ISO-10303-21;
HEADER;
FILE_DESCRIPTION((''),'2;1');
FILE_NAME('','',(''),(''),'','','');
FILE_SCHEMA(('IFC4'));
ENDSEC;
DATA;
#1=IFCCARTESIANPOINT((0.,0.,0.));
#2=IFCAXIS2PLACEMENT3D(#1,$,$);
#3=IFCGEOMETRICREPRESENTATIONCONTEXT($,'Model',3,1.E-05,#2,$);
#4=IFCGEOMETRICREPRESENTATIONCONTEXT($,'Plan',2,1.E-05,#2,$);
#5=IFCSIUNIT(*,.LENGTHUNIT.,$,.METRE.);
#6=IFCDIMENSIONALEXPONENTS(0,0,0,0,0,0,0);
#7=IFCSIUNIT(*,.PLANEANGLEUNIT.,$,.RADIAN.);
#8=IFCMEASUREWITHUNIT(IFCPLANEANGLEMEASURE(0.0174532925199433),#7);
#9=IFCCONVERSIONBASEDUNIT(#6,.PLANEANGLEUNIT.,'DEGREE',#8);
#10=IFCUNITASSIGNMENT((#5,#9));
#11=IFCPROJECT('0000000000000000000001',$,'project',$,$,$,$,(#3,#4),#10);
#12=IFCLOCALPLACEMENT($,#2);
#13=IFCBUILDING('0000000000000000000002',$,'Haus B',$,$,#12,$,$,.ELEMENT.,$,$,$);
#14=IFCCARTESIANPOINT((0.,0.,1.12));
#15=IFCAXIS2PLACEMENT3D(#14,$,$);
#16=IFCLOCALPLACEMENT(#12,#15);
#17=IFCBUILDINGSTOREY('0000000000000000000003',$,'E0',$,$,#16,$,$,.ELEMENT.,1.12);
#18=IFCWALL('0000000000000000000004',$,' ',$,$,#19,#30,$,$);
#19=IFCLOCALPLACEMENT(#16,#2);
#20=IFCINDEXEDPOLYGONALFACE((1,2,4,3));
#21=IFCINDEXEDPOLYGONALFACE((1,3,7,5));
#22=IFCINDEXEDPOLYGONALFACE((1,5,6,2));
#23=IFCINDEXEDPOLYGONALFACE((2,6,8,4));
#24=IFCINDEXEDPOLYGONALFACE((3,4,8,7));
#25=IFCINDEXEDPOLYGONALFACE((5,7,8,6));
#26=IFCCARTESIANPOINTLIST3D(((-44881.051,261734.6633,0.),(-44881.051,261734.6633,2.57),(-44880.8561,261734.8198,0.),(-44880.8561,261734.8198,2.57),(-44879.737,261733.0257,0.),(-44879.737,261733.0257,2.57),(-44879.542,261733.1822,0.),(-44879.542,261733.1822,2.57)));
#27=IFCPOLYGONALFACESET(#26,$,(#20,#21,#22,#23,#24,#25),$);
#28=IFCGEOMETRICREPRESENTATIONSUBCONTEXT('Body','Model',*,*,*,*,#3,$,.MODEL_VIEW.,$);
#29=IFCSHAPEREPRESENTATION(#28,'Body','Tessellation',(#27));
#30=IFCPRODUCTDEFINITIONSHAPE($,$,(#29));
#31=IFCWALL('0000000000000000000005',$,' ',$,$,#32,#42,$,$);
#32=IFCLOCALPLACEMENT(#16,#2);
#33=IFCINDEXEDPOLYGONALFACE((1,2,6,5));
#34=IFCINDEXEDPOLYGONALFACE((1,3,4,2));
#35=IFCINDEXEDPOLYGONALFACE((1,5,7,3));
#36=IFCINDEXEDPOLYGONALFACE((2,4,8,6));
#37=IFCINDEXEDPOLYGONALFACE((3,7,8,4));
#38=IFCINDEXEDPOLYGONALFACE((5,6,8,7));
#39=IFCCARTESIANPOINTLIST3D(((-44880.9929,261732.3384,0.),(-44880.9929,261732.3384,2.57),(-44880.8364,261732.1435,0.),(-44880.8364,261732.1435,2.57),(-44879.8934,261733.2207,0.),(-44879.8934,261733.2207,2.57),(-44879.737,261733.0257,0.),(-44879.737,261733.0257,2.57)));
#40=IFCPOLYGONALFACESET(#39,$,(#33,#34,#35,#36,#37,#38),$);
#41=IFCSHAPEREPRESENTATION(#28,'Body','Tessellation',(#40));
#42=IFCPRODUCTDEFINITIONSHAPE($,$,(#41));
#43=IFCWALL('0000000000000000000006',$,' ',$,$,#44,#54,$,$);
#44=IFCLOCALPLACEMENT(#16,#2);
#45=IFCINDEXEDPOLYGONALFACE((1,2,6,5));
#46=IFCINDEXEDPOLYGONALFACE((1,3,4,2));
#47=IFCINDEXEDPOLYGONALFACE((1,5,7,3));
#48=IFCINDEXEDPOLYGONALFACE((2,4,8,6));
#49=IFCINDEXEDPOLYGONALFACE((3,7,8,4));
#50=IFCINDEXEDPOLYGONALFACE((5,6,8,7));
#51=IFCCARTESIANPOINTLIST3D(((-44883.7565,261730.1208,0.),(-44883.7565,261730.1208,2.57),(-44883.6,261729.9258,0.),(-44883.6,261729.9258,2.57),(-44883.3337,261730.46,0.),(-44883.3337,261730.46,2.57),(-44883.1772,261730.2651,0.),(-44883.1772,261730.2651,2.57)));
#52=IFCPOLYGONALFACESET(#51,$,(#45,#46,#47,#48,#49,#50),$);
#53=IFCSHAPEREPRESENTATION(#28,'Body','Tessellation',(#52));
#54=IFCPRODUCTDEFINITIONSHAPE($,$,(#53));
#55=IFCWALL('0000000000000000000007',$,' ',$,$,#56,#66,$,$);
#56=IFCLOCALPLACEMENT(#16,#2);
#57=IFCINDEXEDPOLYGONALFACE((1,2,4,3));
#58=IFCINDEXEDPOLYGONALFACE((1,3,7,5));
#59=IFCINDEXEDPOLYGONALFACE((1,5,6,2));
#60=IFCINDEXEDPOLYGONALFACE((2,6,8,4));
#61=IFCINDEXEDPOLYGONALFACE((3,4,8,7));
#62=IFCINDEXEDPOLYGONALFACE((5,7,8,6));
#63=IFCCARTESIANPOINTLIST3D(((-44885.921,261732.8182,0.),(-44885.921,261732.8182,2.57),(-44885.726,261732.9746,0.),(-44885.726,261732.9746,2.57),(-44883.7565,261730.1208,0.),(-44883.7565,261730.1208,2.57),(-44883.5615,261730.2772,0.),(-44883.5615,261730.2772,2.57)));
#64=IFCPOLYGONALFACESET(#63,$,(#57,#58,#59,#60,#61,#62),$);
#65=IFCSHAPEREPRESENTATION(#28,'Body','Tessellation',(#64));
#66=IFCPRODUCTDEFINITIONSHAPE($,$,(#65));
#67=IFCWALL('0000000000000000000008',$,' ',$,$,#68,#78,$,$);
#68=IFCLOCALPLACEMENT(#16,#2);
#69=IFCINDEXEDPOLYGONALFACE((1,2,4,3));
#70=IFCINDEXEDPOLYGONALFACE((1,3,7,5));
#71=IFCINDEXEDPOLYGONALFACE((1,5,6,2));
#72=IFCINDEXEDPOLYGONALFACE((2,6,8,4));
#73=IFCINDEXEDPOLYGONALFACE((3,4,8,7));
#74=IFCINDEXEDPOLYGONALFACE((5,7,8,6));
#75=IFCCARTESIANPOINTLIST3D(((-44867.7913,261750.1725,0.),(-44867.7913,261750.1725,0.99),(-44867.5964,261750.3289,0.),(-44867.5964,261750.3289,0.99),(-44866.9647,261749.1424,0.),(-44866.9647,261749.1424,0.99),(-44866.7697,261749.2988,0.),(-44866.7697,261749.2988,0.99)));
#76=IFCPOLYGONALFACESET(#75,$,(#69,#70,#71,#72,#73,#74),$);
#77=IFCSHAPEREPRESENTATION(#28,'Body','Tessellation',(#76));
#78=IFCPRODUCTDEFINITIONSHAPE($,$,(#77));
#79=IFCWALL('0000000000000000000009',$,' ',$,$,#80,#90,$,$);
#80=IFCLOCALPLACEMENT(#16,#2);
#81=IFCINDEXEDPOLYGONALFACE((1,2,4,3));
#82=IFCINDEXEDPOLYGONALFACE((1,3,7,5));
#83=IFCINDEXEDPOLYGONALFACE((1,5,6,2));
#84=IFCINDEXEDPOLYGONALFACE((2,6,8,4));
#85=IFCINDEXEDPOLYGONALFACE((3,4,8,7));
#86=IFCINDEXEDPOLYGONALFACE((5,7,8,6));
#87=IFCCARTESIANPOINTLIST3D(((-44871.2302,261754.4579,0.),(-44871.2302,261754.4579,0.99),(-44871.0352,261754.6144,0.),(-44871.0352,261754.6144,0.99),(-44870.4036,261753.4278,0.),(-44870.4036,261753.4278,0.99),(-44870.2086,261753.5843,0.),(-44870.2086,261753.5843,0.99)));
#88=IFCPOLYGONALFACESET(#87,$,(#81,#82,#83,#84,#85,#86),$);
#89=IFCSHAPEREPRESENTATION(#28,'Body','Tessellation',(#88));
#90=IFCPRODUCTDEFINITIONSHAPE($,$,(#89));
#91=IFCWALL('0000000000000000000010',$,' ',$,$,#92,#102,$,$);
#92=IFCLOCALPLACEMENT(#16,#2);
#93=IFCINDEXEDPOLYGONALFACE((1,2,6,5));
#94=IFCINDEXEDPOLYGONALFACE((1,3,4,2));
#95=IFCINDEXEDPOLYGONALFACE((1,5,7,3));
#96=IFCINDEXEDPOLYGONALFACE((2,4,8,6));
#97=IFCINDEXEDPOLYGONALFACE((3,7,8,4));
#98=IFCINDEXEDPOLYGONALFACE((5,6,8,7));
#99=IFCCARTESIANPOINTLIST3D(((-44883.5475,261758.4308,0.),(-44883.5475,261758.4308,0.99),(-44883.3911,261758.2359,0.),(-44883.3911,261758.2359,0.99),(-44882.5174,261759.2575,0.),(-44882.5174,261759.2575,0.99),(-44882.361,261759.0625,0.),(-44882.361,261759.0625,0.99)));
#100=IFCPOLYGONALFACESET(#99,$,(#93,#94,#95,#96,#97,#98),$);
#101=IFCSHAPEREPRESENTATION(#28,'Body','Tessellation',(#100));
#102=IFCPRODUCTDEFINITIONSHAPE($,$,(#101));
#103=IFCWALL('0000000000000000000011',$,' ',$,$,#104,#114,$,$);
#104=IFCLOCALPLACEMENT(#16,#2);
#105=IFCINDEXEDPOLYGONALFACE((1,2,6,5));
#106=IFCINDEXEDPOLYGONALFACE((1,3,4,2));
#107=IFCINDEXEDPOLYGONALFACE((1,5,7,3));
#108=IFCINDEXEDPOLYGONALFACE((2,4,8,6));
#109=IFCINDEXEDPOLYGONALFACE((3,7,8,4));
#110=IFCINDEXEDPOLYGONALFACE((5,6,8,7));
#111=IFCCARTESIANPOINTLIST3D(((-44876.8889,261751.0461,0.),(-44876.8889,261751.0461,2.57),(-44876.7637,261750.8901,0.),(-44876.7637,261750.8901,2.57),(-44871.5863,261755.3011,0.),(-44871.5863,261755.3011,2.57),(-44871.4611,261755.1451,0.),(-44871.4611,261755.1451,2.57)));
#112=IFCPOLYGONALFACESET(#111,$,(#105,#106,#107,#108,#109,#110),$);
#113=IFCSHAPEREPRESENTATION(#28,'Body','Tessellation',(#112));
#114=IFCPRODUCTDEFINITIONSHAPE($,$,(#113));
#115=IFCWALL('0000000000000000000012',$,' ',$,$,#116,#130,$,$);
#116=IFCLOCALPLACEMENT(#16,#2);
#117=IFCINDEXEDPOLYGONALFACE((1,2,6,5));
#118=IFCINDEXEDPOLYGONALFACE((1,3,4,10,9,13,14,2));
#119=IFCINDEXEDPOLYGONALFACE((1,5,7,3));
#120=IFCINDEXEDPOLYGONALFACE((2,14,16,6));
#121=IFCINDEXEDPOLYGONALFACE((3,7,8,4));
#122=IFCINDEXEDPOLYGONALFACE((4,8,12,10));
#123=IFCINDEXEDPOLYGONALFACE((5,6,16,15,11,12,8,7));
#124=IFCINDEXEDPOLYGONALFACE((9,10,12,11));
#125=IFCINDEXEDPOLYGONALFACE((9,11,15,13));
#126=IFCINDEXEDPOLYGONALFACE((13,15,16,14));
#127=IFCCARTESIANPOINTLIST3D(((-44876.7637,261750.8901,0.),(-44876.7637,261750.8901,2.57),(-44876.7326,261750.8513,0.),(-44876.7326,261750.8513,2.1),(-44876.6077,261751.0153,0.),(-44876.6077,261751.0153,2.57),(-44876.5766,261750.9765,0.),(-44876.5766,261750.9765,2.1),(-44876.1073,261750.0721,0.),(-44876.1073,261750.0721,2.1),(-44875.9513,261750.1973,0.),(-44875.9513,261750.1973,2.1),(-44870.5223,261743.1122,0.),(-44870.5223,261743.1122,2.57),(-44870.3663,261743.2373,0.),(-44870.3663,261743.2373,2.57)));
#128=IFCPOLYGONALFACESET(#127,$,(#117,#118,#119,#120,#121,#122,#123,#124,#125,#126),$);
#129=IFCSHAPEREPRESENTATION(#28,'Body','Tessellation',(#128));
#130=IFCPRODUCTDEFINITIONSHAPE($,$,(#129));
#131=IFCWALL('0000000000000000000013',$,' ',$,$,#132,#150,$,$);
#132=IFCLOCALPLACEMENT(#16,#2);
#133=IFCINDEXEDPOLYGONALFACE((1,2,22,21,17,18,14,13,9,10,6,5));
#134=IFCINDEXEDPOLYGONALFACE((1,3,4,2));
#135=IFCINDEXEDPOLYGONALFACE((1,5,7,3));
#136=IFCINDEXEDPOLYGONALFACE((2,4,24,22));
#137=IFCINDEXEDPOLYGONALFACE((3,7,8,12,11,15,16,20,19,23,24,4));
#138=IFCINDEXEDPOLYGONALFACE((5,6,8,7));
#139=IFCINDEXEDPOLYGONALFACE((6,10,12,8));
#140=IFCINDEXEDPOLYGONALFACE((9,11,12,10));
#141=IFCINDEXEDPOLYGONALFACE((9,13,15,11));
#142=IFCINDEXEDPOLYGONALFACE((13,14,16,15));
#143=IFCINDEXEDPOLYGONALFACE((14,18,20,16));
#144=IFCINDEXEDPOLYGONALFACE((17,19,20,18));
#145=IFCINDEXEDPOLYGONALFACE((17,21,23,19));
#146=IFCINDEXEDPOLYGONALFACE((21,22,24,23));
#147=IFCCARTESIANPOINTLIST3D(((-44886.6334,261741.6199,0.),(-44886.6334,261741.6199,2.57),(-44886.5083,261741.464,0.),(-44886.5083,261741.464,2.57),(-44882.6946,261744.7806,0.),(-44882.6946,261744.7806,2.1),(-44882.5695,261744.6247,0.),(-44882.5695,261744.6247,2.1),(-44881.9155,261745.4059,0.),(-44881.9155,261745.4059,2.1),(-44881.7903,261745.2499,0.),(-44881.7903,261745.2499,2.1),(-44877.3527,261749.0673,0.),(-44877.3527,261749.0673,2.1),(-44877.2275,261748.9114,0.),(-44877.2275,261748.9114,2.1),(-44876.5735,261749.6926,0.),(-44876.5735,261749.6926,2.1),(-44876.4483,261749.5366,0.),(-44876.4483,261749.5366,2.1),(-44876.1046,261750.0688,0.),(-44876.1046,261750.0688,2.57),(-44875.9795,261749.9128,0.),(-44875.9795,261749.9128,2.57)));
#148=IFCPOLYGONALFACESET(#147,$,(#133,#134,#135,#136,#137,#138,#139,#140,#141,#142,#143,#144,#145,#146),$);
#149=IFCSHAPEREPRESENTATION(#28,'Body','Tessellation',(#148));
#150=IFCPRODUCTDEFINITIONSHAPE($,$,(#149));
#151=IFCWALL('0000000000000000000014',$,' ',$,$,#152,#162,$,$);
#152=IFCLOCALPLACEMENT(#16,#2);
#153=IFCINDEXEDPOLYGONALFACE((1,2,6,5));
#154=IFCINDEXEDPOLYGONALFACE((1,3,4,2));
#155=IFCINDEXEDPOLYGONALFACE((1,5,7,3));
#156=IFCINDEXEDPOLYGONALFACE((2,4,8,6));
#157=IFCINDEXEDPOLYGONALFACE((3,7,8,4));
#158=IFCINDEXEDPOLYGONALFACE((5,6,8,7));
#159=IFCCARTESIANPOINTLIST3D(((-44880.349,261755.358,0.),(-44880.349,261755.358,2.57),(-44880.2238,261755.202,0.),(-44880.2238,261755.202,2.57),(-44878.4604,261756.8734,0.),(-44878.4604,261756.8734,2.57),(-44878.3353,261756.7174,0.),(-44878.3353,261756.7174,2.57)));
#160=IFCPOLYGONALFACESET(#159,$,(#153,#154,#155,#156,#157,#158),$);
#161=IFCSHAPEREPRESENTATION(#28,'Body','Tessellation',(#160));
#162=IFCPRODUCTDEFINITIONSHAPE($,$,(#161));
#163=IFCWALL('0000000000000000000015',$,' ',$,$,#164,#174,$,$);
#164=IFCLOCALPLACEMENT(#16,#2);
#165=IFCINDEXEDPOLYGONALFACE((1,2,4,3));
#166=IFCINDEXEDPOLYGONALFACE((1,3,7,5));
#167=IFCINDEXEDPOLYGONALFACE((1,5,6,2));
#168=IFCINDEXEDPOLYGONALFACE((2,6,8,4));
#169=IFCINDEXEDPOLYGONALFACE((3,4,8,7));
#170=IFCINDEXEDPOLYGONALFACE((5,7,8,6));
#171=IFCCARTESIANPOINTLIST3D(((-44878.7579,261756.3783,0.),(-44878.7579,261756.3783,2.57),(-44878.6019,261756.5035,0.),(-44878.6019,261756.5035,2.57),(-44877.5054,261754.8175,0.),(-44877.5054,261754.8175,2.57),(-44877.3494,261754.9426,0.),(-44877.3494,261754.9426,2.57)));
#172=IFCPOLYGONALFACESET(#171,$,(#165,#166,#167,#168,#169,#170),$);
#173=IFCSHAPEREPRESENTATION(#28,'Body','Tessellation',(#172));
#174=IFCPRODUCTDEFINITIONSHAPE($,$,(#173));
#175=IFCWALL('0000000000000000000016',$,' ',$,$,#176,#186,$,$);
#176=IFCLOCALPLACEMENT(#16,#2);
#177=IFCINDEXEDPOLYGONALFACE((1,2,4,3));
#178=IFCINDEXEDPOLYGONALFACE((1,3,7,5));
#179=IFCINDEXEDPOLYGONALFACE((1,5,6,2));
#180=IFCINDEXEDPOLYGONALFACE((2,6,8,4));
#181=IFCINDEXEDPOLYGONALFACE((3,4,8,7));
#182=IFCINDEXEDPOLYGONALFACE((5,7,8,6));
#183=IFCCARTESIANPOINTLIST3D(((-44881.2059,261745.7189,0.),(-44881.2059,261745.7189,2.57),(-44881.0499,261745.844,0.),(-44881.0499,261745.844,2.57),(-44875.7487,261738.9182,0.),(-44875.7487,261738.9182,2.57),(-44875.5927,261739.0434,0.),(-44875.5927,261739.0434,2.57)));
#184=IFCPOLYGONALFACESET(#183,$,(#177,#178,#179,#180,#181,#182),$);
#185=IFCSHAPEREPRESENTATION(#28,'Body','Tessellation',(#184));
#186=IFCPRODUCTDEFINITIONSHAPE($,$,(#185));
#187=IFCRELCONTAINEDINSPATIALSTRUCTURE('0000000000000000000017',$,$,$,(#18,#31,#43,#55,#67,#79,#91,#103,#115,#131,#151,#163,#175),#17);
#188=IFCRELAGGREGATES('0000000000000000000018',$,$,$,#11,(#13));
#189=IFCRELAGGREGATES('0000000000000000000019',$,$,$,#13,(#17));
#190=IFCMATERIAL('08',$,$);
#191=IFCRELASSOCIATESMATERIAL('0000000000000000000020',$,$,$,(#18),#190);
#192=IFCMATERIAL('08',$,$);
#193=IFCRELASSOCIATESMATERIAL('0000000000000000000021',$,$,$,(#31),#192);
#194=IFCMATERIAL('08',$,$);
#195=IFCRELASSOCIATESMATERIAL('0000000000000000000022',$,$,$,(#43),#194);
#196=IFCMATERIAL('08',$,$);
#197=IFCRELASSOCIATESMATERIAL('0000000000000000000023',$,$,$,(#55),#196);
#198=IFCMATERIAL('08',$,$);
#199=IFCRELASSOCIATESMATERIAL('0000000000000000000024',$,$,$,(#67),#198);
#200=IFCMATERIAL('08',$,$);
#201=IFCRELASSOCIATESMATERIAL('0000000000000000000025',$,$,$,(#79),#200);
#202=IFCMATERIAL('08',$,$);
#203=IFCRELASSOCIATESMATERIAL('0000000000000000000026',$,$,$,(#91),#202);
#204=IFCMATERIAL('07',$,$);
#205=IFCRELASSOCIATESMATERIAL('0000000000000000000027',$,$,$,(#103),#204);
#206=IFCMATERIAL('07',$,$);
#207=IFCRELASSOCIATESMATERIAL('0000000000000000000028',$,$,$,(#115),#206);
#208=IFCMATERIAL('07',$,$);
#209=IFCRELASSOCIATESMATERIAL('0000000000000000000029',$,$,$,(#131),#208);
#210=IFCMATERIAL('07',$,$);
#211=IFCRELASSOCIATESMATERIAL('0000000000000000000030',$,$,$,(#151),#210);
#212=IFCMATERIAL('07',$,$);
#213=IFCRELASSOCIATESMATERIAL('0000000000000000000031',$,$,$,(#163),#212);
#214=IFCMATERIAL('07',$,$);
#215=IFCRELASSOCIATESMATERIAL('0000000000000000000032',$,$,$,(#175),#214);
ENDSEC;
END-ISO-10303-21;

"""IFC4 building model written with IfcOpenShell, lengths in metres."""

from ifc_helpers import new_model, entity, si_unit, converted_unit, frame, frame_2d, origin, origin_with_axes, place, context, subcontext, project, spatial, polyline, rectangle, outline, extrude, material, element, save


model = new_model("IFC4")

# Units and contexts
model_context = context("Model", 3, precision=1e-05, world=origin())
plan_context = context("Plan", 2, precision=1e-05, world=origin())
body_context = subcontext(model_context, "Body", "Model", "MODEL_VIEW")
ifc_project = project(units=[si_unit("LENGTHUNIT", "METRE"), converted_unit("PLANEANGLEUNIT", "DEGREE", entity("IfcPlaneAngleMeasure", 0.0174532925199433), si_unit("PLANEANGLEUNIT", "RADIAN"), dimensions=[0, 0, 0, 0, 0, 0, 0])], contexts=[model_context, plan_context])

# Building, storey
building_placement = place(None, origin())
building = spatial("IfcBuilding", under=ifc_project, at=building_placement, Name="Haus B", CompositionType="ELEMENT")
storey_placement = place(building_placement, frame((0.0, 0.0, 1.12)))
storey = spatial("IfcBuildingStorey", under=building, at=storey_placement, Name="E0", CompositionType="ELEMENT", Elevation=1.12)

# Walls
ifc_material_1 = material(Name="08")
wall_1_placement = place(storey_placement, frame((-44881.051, 261734.6633, 0.0), z_axis=(0.0, 0.0, 1.0), x_axis=(0.625861, -0.779935, 0.0)))
element("IfcWall", 1, at=wall_1_placement, inside=storey, material=ifc_material_1, Name=" ", context=body_context, shape_type="SweptSolid", body=[
    extrude(rectangle(XDim=2.0997, YDim=0.25, at=frame_2d((1.0498, 0.125), x_axis=(1.0, 0.0))), origin_with_axes(), (0.0, 0.0, 1.0), 2.57),
])
ifc_material_2 = material(Name="08")
wall_2_placement = place(storey_placement, frame((-44879.8934, 261733.2207, 0.0), z_axis=(0.0, 0.0, 1.0), x_axis=(-0.779935, -0.625861, 0.0)))
element("IfcWall", 2, at=wall_2_placement, inside=storey, material=ifc_material_2, Name=" ", context=body_context, shape_type="SweptSolid", body=[
    extrude(rectangle(XDim=1.4096, YDim=0.25, at=frame_2d((0.7048, 0.125), x_axis=(1.0, 0.0))), origin_with_axes(), (0.0, 0.0, 1.0), 2.57),
])
ifc_material_3 = material(Name="08")
wall_3_placement = place(storey_placement, frame((-44883.3337, 261730.46, 0.0), z_axis=(0.0, 0.0, 1.0), x_axis=(-0.779935, -0.625861, 0.0)))
element("IfcWall", 3, at=wall_3_placement, inside=storey, material=ifc_material_3, Name=" ", context=body_context, shape_type="SweptSolid", body=[
    extrude(rectangle(XDim=0.5421, YDim=0.25, at=frame_2d((0.271, 0.125), x_axis=(1.0, 0.0))), origin_with_axes(), (0.0, 0.0, 1.0), 2.57),
])
ifc_material_4 = material(Name="08")
wall_4_placement = place(storey_placement, frame((-44883.5615, 261730.2772, 0.0), z_axis=(0.0, 0.0, 1.0), x_axis=(-0.625861, 0.779935, 0.0)))
element("IfcWall", 4, at=wall_4_placement, inside=storey, material=ifc_material_4, Name=" ", context=body_context, shape_type="SweptSolid", body=[
    extrude(rectangle(XDim=3.4585, YDim=0.25, at=frame_2d((1.7292, 0.125), x_axis=(1.0, 0.0))), origin_with_axes(), (0.0, 0.0, 1.0), 2.57),
])
ifc_material_5 = material(Name="08")
wall_5_placement = place(storey_placement, frame((-44867.7913, 261750.1725, 0.0), z_axis=(0.0, 0.0, 1.0), x_axis=(0.625861, -0.779935, 0.0)))
element("IfcWall", 5, at=wall_5_placement, inside=storey, material=ifc_material_5, Name=" ", context=body_context, shape_type="SweptSolid", body=[
    extrude(rectangle(XDim=1.3207, YDim=0.25, at=frame_2d((0.6604, 0.125), x_axis=(1.0, 0.0))), origin_with_axes(), (0.0, 0.0, 1.0), 0.99),
])
ifc_material_6 = material(Name="08")
wall_6_placement = place(storey_placement, frame((-44871.2302, 261754.4579, 0.0), z_axis=(0.0, 0.0, 1.0), x_axis=(0.625861, -0.779935, 0.0)))
element("IfcWall", 6, at=wall_6_placement, inside=storey, material=ifc_material_6, Name=" ", context=body_context, shape_type="SweptSolid", body=[
    extrude(rectangle(XDim=1.3207, YDim=0.25, at=frame_2d((0.6604, 0.125), x_axis=(1.0, 0.0))), origin_with_axes(), (0.0, 0.0, 1.0), 0.99),
])
ifc_material_7 = material(Name="08")
wall_7_placement = place(storey_placement, frame((-44883.3911, 261758.2359, 0.0), z_axis=(0.0, 0.0, 1.0), x_axis=(0.779935, 0.625861, 0.0)))
element("IfcWall", 7, at=wall_7_placement, inside=storey, material=ifc_material_7, Name=" ", context=body_context, shape_type="SweptSolid", body=[
    extrude(rectangle(XDim=1.3207, YDim=0.25, at=frame_2d((0.6604, 0.125), x_axis=(1.0, 0.0))), origin_with_axes(), (0.0, 0.0, 1.0), 0.99),
])
ifc_material_8 = material(Name="07")
wall_8_placement = place(storey_placement, frame((-44871.5863, 261755.3011, 0.0), z_axis=(0.0, 0.0, 1.0), x_axis=(-0.779935, -0.625861, 0.0)))
element("IfcWall", 8, at=wall_8_placement, inside=storey, material=ifc_material_8, Name=" ", context=body_context, shape_type="SweptSolid", body=[
    extrude(rectangle(XDim=6.7987, YDim=0.2, at=frame_2d((3.3994, 0.1), x_axis=(1.0, 0.0))), origin_with_axes(), (0.0, 0.0, 1.0), 2.57),
])

# Wall, opening
ifc_material_9 = material(Name="07")
wall_9_placement = place(storey_placement, frame((-44876.7637, 261750.8901, 0.0), z_axis=(0.0, 0.0, 1.0), x_axis=(0.625861, -0.779935, 0.0)))
wall_9 = element("IfcWall", 9, at=wall_9_placement, inside=storey, material=ifc_material_9, Name=" ", context=body_context, shape_type="SweptSolid", body=[
    extrude(rectangle(XDim=9.9725, YDim=0.2, at=frame_2d((4.9863, 0.1), x_axis=(1.0, 0.0))), origin_with_axes(), (0.0, 0.0, 1.0), 2.57),
])
opening_1_placement = place(wall_9_placement, frame((1.0488, 0.2, 0.0), z_axis=(0.0, -1.0, 0.0), x_axis=(0.0, 0.0, 1.0)))
element("IfcOpeningElement", 10, at=opening_1_placement, cuts=wall_9, ObjectType="Opening", context=body_context, shape_type="SweptSolid", body=[
    extrude(outline(polyline([(0.0, 0.999), (2.1, 0.999), (2.1, 0.0), (0.0, 0.0), (0.0, 0.999)])), origin_with_axes(), (0.0, 0.0, 1.0), 0.2),
])

# Wall, openings
ifc_material_10 = material(Name="07")
wall_10_placement = place(storey_placement, frame((-44876.1046, 261750.0688, 0.0), z_axis=(0.0, 0.0, 1.0), x_axis=(-0.779935, -0.625861, 0.0)))
wall_10 = element("IfcWall", 11, at=wall_10_placement, inside=storey, material=ifc_material_10, Name=" ", context=body_context, shape_type="SweptSolid", body=[
    extrude(rectangle(XDim=13.4996, YDim=0.2, at=frame_2d((6.7498, 0.1), x_axis=(1.0, 0.0))), origin_with_axes(), (0.0, 0.0, 1.0), 2.57),
])
opening_2_placement = place(wall_10_placement, frame((8.4494, 0.2, 0.0), z_axis=(0.0, -1.0, 0.0), x_axis=(0.0, 0.0, 1.0)))
element("IfcOpeningElement", 12, at=opening_2_placement, cuts=wall_10, ObjectType="Opening", context=body_context, shape_type="SweptSolid", body=[
    extrude(outline(polyline([(0.0, 0.999), (0.0, 0.0), (2.1, 0.0), (2.1, 0.999), (0.0, 0.999)])), origin_with_axes(), (0.0, 0.0, 1.0), 0.2),
])
opening_3_placement = place(wall_10_placement, frame((1.6001, 0.2, 0.0), z_axis=(0.0, -1.0, 0.0), x_axis=(0.0, 0.0, 1.0)))
element("IfcOpeningElement", 13, at=opening_3_placement, cuts=wall_10, ObjectType="Opening", context=body_context, shape_type="SweptSolid", body=[
    extrude(outline(polyline([(0.0, 0.999), (0.0, 0.0), (2.1, 0.0), (2.1, 0.999), (0.0, 0.999)])), origin_with_axes(), (0.0, 0.0, 1.0), 0.2),
])

# Wall
ifc_material_11 = material(Name="07")
wall_11_placement = place(storey_placement, frame((-44878.4604, 261756.8734, 0.0), z_axis=(0.0, 0.0, 1.0), x_axis=(-0.779935, -0.625861, 0.0)))
element("IfcWall", 14, at=wall_11_placement, inside=storey, material=ifc_material_11, Name=" ", context=body_context, shape_type="SweptSolid", body=[
    extrude(rectangle(XDim=2.4214, YDim=0.2, at=frame_2d((1.2107, 0.1), x_axis=(1.0, 0.0))), origin_with_axes(), (0.0, 0.0, 1.0), 2.57),
])

# Walls
ifc_material_12 = material(Name="07")
wall_12_placement = place(storey_placement, frame((-44878.7579, 261756.3783, 0.0), z_axis=(0.0, 0.0, 1.0), x_axis=(0.625861, -0.779935, 0.0)))
element("IfcWall", 15, at=wall_12_placement, inside=storey, material=ifc_material_12, Name=" ", context=body_context, shape_type="SweptSolid", body=[
    extrude(rectangle(XDim=2.0012, YDim=0.2, at=frame_2d((1.0006, 0.1), x_axis=(1.0, 0.0))), origin_with_axes(), (0.0, 0.0, 1.0), 2.57),
])
ifc_material_13 = material(Name="07")
wall_13_placement = place(storey_placement, frame((-44881.2059, 261745.7189, 0.0), z_axis=(0.0, 0.0, 1.0), x_axis=(0.625861, -0.779935, 0.0)))
element("IfcWall", 16, at=wall_13_placement, inside=storey, material=ifc_material_13, Name=" ", context=body_context, shape_type="SweptSolid", body=[
    extrude(rectangle(XDim=8.7195, YDim=0.2, at=frame_2d((4.3598, 0.1), x_axis=(1.0, 0.0))), origin_with_axes(), (0.0, 0.0, 1.0), 2.57),
])

save(model, "model.ifc")
